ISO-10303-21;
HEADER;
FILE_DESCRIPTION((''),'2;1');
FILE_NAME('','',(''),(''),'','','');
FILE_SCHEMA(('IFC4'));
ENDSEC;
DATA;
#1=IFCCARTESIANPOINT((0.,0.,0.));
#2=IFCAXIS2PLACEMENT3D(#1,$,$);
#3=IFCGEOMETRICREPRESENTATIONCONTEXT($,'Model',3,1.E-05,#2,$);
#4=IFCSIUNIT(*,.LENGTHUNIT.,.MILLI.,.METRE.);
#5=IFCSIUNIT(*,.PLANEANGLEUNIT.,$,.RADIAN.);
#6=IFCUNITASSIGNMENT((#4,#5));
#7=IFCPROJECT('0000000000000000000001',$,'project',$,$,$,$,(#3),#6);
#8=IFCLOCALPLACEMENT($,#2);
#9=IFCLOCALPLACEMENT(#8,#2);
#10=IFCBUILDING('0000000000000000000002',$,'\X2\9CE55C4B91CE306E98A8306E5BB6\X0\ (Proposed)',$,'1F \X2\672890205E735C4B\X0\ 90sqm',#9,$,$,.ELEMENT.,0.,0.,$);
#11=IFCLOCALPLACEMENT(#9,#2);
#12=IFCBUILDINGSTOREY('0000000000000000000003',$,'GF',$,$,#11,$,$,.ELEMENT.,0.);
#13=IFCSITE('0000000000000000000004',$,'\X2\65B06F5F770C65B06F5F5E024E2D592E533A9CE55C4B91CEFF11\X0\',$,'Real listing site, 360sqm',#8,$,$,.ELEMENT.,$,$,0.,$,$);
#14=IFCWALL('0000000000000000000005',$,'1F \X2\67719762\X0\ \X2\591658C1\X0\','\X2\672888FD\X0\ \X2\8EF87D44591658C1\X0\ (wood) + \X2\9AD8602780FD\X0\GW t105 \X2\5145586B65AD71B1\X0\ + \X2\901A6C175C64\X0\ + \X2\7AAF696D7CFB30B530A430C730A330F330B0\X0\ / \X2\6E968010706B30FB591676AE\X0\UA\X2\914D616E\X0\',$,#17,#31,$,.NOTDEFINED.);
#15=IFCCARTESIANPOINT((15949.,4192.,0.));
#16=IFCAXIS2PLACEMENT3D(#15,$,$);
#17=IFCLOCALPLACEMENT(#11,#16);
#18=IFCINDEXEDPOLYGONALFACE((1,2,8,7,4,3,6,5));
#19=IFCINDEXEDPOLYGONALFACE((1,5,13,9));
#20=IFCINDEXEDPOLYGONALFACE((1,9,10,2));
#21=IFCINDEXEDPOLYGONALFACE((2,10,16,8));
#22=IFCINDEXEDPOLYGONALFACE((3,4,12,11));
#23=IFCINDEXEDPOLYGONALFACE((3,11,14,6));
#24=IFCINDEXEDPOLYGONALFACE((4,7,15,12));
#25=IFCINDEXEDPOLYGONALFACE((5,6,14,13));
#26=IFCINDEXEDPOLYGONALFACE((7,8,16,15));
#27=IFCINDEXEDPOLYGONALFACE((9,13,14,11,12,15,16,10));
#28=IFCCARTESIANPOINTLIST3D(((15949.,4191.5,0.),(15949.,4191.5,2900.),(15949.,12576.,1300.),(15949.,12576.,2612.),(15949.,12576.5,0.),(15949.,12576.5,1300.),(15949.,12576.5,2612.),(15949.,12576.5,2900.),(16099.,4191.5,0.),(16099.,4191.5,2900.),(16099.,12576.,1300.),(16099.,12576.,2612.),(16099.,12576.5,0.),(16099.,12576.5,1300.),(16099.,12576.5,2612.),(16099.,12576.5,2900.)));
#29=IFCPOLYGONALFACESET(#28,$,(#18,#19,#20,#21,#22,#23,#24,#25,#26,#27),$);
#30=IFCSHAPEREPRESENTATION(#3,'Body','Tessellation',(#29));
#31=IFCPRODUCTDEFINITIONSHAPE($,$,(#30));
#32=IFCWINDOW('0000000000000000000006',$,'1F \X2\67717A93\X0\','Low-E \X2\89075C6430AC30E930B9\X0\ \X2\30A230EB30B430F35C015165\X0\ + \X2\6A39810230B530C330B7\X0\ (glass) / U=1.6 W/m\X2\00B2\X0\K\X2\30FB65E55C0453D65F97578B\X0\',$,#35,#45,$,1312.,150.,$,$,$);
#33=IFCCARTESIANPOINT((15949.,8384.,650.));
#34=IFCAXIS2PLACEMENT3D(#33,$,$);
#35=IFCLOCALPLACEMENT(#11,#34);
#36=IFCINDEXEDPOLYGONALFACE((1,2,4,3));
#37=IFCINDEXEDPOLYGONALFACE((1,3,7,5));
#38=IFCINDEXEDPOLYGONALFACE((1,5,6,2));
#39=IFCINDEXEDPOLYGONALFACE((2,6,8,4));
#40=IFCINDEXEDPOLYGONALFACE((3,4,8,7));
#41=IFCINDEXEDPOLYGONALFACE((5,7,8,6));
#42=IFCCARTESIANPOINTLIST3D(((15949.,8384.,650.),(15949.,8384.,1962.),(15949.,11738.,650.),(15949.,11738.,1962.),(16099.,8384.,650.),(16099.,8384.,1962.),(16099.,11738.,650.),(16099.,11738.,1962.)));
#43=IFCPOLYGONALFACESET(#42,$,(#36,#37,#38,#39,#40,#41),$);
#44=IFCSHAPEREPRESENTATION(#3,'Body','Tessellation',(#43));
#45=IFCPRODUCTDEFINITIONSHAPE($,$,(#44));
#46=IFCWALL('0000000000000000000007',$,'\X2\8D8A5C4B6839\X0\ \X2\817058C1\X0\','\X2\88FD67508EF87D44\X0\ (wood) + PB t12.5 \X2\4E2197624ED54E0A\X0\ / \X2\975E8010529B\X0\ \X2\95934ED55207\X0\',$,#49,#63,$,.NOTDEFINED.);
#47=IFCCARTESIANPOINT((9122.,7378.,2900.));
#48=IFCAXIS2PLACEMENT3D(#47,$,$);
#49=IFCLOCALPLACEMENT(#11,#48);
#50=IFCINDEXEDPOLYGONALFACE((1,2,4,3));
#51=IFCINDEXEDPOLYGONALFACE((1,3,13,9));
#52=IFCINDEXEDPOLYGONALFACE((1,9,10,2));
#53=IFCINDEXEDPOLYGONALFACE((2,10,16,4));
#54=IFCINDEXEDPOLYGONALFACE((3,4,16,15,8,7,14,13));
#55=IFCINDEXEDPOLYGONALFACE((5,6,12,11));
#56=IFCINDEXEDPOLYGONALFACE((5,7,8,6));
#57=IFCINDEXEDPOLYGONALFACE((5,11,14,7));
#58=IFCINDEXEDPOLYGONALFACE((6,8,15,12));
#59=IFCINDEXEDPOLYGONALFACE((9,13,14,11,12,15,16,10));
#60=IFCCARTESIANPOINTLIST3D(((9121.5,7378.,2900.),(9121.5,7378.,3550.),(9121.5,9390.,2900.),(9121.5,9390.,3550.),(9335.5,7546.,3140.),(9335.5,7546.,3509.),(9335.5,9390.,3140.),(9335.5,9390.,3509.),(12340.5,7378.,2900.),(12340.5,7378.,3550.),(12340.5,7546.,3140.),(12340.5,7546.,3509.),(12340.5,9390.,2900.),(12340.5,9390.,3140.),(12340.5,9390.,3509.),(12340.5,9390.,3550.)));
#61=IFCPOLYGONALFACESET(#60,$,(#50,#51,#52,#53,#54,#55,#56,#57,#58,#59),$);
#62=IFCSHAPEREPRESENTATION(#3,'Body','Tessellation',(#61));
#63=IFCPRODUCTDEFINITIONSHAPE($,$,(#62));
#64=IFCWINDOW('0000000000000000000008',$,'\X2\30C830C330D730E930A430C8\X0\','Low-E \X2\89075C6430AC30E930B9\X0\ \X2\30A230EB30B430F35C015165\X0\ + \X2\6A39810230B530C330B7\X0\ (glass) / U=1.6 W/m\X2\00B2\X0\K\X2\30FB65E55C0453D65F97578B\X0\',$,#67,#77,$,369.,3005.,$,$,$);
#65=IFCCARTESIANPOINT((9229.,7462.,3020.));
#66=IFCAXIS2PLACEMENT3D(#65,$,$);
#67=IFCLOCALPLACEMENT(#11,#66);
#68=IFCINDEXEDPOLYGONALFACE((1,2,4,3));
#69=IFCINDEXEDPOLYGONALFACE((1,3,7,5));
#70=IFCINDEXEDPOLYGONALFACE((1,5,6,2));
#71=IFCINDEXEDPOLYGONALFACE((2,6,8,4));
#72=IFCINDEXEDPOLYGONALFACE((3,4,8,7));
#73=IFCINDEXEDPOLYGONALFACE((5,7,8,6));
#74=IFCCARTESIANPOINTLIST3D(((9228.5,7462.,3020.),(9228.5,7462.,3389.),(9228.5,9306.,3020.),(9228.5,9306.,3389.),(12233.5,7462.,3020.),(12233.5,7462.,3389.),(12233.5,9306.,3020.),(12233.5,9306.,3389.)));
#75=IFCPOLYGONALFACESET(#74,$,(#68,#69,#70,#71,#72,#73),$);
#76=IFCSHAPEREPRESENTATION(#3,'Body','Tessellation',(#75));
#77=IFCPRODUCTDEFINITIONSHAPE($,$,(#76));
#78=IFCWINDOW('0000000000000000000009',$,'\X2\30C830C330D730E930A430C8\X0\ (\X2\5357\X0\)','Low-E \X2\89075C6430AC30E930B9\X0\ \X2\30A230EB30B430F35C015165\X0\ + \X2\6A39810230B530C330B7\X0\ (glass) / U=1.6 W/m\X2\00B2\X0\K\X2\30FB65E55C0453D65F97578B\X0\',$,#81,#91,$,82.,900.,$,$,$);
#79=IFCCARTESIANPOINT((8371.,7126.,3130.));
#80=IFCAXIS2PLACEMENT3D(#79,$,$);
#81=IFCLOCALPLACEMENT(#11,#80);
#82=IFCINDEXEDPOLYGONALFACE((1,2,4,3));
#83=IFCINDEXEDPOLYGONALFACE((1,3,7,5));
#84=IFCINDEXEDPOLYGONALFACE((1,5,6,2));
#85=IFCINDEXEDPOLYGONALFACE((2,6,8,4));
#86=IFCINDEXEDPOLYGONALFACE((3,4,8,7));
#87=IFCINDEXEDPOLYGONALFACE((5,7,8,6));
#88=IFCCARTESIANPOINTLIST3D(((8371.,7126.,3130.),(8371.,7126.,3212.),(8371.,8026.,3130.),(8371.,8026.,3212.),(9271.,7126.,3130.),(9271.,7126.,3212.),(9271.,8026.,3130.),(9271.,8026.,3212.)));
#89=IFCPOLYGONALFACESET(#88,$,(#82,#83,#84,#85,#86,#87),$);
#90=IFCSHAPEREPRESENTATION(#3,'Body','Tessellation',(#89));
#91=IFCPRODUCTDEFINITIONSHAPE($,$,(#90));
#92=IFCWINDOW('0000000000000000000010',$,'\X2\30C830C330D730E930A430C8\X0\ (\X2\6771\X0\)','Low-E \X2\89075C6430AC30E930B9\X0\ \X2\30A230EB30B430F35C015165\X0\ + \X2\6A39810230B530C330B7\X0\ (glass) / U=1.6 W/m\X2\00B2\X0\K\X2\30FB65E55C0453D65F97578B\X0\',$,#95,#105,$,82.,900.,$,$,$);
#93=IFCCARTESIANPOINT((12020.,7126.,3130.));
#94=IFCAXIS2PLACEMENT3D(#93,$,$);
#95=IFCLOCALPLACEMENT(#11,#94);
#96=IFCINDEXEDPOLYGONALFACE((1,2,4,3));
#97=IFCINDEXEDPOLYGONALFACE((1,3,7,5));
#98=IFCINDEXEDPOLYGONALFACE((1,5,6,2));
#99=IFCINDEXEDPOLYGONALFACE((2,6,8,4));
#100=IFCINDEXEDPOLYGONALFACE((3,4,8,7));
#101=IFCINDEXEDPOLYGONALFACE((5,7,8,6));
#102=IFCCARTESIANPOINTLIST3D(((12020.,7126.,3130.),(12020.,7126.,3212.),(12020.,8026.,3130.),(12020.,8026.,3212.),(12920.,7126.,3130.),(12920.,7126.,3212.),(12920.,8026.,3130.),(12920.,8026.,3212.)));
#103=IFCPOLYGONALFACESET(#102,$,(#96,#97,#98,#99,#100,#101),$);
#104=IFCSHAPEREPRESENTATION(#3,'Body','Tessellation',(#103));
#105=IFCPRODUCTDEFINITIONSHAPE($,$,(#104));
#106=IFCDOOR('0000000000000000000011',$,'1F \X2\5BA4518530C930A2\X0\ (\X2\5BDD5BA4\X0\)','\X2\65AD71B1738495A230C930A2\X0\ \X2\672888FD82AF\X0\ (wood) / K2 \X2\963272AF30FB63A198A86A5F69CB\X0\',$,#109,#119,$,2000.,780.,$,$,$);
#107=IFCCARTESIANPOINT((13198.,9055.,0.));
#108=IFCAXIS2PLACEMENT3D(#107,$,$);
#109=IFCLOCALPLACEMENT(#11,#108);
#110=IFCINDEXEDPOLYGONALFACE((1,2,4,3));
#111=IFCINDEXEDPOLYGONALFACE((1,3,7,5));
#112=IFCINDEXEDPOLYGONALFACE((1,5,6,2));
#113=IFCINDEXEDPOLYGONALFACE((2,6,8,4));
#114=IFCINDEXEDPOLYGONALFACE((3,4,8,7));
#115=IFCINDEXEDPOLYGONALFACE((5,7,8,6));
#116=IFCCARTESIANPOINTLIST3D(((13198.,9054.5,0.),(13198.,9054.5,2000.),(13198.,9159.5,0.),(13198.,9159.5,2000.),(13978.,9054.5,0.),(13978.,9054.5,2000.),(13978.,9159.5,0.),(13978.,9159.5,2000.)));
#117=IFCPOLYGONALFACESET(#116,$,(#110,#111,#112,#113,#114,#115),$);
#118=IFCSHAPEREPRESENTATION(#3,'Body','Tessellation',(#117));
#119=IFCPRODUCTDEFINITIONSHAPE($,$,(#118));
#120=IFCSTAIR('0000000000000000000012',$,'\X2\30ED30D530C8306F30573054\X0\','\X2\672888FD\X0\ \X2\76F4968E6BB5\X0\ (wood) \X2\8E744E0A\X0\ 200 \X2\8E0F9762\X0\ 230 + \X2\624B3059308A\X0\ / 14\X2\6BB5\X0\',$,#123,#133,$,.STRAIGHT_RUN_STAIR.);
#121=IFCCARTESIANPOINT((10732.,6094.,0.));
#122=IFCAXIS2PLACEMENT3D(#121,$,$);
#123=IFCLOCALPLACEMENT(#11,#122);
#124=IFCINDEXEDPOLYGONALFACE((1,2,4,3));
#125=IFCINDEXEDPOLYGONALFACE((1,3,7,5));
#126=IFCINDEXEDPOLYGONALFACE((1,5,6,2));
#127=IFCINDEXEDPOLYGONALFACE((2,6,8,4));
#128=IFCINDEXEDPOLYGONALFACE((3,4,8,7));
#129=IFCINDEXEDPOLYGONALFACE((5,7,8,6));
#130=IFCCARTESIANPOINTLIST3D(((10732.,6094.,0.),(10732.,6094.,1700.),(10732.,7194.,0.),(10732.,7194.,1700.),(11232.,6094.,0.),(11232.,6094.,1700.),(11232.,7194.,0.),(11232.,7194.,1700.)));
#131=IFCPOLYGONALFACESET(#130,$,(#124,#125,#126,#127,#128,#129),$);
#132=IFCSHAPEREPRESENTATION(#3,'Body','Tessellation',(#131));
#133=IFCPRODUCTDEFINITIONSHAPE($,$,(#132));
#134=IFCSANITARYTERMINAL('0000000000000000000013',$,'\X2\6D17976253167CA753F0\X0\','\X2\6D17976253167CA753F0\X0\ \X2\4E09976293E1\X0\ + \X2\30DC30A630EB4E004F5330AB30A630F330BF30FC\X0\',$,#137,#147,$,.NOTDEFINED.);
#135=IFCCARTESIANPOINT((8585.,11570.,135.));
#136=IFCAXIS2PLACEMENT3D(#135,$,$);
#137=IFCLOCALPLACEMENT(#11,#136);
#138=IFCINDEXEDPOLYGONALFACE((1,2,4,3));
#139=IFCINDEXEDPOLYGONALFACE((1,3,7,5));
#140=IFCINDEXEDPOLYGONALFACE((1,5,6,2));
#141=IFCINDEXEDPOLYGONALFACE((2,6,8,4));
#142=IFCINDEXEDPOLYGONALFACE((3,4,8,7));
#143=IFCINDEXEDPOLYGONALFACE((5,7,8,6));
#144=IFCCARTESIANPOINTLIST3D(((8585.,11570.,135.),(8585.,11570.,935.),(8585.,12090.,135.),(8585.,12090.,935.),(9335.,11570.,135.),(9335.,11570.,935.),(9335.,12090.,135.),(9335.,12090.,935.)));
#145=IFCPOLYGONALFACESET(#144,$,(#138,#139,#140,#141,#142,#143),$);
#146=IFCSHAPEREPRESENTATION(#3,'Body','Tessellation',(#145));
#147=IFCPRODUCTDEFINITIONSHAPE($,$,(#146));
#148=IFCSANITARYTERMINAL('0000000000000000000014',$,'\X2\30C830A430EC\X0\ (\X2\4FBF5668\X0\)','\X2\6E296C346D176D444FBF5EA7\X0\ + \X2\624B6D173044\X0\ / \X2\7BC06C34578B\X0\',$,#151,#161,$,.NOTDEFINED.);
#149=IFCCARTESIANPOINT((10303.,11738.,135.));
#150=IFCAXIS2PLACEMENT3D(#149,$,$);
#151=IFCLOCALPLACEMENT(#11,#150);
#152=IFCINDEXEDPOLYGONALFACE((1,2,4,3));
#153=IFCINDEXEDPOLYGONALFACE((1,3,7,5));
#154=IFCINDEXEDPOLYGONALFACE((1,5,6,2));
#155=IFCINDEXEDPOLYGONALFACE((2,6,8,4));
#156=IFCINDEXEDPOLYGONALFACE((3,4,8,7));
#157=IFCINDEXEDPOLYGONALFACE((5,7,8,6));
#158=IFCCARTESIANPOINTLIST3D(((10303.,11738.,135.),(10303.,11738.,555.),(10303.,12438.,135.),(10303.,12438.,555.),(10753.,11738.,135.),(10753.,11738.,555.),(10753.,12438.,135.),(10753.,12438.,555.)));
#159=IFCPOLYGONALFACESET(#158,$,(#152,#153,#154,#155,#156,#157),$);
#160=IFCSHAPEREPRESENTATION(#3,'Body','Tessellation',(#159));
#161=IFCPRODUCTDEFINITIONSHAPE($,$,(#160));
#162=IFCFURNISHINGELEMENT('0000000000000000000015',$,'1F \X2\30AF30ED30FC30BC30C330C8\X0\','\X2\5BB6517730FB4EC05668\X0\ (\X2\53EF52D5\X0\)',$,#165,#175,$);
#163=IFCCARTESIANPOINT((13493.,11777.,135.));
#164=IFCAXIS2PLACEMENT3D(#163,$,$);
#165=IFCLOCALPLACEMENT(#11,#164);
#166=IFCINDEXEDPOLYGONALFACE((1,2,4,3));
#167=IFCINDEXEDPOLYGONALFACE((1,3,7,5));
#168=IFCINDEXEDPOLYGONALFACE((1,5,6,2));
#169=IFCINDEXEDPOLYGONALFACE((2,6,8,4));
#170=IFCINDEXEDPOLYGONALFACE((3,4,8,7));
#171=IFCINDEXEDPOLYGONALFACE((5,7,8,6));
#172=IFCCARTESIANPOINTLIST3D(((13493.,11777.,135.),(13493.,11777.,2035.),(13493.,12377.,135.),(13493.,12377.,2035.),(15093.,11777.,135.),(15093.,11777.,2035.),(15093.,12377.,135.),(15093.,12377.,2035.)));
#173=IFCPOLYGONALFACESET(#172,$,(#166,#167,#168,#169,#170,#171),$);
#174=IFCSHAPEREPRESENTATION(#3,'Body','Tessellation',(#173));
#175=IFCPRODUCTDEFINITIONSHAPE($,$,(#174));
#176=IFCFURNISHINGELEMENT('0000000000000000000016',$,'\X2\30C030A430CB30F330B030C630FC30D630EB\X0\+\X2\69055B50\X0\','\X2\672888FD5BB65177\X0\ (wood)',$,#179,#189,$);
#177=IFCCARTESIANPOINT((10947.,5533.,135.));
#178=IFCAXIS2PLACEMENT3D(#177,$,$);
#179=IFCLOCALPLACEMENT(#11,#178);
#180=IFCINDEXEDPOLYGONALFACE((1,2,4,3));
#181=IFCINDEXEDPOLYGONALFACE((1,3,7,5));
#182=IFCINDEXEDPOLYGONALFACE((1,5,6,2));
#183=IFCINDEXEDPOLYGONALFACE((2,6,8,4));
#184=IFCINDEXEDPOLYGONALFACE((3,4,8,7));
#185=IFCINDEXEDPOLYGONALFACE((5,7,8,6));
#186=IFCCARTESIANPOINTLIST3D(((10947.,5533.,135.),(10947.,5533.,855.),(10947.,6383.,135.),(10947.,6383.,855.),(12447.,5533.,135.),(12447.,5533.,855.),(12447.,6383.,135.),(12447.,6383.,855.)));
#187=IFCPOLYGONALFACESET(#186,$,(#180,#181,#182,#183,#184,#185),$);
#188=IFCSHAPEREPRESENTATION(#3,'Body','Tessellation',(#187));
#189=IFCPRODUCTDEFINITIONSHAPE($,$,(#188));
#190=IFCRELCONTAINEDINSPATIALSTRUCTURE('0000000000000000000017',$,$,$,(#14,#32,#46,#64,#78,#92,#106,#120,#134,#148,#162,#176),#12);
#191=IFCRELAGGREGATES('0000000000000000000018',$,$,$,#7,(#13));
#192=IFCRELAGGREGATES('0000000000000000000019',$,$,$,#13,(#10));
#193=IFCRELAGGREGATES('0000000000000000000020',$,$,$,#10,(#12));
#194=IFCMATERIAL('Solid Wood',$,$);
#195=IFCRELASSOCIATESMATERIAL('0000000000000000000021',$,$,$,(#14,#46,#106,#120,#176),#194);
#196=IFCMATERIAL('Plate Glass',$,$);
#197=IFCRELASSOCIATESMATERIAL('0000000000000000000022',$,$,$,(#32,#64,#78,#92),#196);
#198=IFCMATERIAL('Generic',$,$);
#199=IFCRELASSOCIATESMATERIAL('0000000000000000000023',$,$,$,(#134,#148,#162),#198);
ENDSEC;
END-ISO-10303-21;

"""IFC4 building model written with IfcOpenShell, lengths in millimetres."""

from ifc_helpers import new_model, si_unit, frame, frame_2d, origin, place, context, project, spatial, rectangle, extrude, material, element, fill, save


model = new_model("IFC4")

# Units and contexts
model_context = context("Model", 3, precision=1e-05, world=origin())
ifc_project = project(units=[si_unit("LENGTHUNIT", "METRE", prefix="MILLI"), si_unit("PLANEANGLEUNIT", "RADIAN")], contexts=[model_context])

# Site, building, storey
site_placement = place(None, origin())
site = spatial("IfcSite", under=ifc_project, at=site_placement, Name="新潟県新潟市中央区鳥屋野１", ObjectType="Real listing site, 360sqm", CompositionType="ELEMENT", RefElevation=0.0)
building_placement = place(site_placement, origin())
building = spatial("IfcBuilding", under=site, at=building_placement, Name="鳥屋野の風の家 (Proposed)", ObjectType="1F 木造平屋 90sqm", CompositionType="ELEMENT", ElevationOfRefHeight=0.0, ElevationOfTerrain=0.0)
storey_placement = place(building_placement, origin())
storey = spatial("IfcBuildingStorey", under=building, at=storey_placement, Name="GF", CompositionType="ELEMENT", Elevation=0.0)

# Wall, opening, window
ifc_material_1 = material(Name="Solid Wood")
wall_1_placement = place(storey_placement, frame((15949.0, 4192.0, 0.0)))
wall_1 = element("IfcWall", 1, at=wall_1_placement, inside=storey, material=ifc_material_1, Name="1F 東面 外壁", Description="木製 軸組外壁 (wood) + 高性能GW t105 充填断熱 + 通気層 + 窯業系サイディング / 準耐火・外皮UA配慮", PredefinedType="NOTDEFINED", context=model_context, shape_type="SweptSolid", body=[
    extrude(rectangle(XDim=150.0, YDim=8385.0, at=frame_2d((75.0, 4192.0))), frame((15949.0, 4192.0, 0.0)), (0.0, 0.0, 1.0), 2900.0),
])
opening_1_placement = place(storey_placement, frame((15949.0, 8384.0, 650.0)))
opening_1 = element("IfcOpeningElement", 2, at=opening_1_placement, cuts=wall_1, PredefinedType="NOTDEFINED", context=model_context, shape_type="SweptSolid", body=[
    extrude(rectangle(XDim=150.0, YDim=3354.0, at=frame_2d((75.0, 1677.0))), frame((15949.0, 8384.0, 650.0)), (0.0, 0.0, 1.0), 1312.0),
])
ifc_material_2 = material(Name="Plate Glass")
window_1_placement = place(storey_placement, frame((15949.0, 8384.0, 650.0)))
window_1 = element("IfcWindow", 3, at=window_1_placement, inside=storey, material=ifc_material_2, Name="1F 東窓", Description="Low-E 複層ガラス アルゴン封入 + 樹脂サッシ (glass) / U=1.6 W/m²K・日射取得型", OverallHeight=1312.0, OverallWidth=150.0, context=model_context, shape_type="SweptSolid", body=[
    extrude(rectangle(XDim=150.0, YDim=3354.0, at=frame_2d((75.0, 1677.0))), frame((15949.0, 8384.0, 650.0)), (0.0, 0.0, 1.0), 1312.0),
])
fill(opening_1, window_1)

# Wall, openings, windows
wall_2_placement = place(storey_placement, frame((9122.0, 7378.0, 2900.0)))
wall_2 = element("IfcWall", 4, at=wall_2_placement, inside=storey, material=ifc_material_1, Name="越屋根 腰壁", Description="製材軸組 (wood) + PB t12.5 両面仕上 / 非耐力 間仕切", PredefinedType="NOTDEFINED", context=model_context, shape_type="SweptSolid", body=[
    extrude(rectangle(XDim=3219.0, YDim=2012.0, at=frame_2d((1609.0, 1006.0))), frame((9122.0, 7378.0, 2900.0)), (0.0, 0.0, 1.0), 650.0),
])
opening_2_placement = place(storey_placement, frame((9229.0, 7462.0, 3020.0)))
opening_2 = element("IfcOpeningElement", 5, at=opening_2_placement, cuts=wall_2, PredefinedType="NOTDEFINED", context=model_context, shape_type="SweptSolid", body=[
    extrude(rectangle(XDim=3005.0, YDim=1844.0, at=frame_2d((1502.0, 922.0))), frame((9229.0, 7462.0, 3020.0)), (0.0, 0.0, 1.0), 369.0),
])
opening_3_placement = place(storey_placement, frame((8371.0, 7126.0, 3130.0)))
opening_3 = element("IfcOpeningElement", 6, at=opening_3_placement, cuts=wall_2, PredefinedType="NOTDEFINED", context=model_context, shape_type="SweptSolid", body=[
    extrude(rectangle(XDim=900.0, YDim=900.0, at=frame_2d((450.0, 450.0))), frame((8371.0, 7126.0, 3130.0)), (0.0, 0.0, 1.0), 82.0),
])
opening_4_placement = place(storey_placement, frame((12020.0, 7126.0, 3130.0)))
opening_4 = element("IfcOpeningElement", 7, at=opening_4_placement, cuts=wall_2, PredefinedType="NOTDEFINED", context=model_context, shape_type="SweptSolid", body=[
    extrude(rectangle(XDim=900.0, YDim=900.0, at=frame_2d((450.0, 450.0))), frame((12020.0, 7126.0, 3130.0)), (0.0, 0.0, 1.0), 82.0),
])
window_2_placement = place(storey_placement, frame((9229.0, 7462.0, 3020.0)))
window_2 = element("IfcWindow", 8, at=window_2_placement, inside=storey, material=ifc_material_2, Name="トップライト", Description="Low-E 複層ガラス アルゴン封入 + 樹脂サッシ (glass) / U=1.6 W/m²K・日射取得型", OverallHeight=369.0, OverallWidth=3005.0, context=model_context, shape_type="SweptSolid", body=[
    extrude(rectangle(XDim=3005.0, YDim=1844.0, at=frame_2d((1502.0, 922.0))), frame((9229.0, 7462.0, 3020.0)), (0.0, 0.0, 1.0), 369.0),
])
fill(opening_2, window_2)
window_3_placement = place(storey_placement, frame((8371.0, 7126.0, 3130.0)))
window_3 = element("IfcWindow", 9, at=window_3_placement, inside=storey, material=ifc_material_2, Name="トップライト (南)", Description="Low-E 複層ガラス アルゴン封入 + 樹脂サッシ (glass) / U=1.6 W/m²K・日射取得型", OverallHeight=82.0, OverallWidth=900.0, context=model_context, shape_type="SweptSolid", body=[
    extrude(rectangle(XDim=900.0, YDim=900.0, at=frame_2d((450.0, 450.0))), frame((8371.0, 7126.0, 3130.0)), (0.0, 0.0, 1.0), 82.0),
])
fill(opening_3, window_3)
window_4_placement = place(storey_placement, frame((12020.0, 7126.0, 3130.0)))
window_4 = element("IfcWindow", 10, at=window_4_placement, inside=storey, material=ifc_material_2, Name="トップライト (東)", Description="Low-E 複層ガラス アルゴン封入 + 樹脂サッシ (glass) / U=1.6 W/m²K・日射取得型", OverallHeight=82.0, OverallWidth=900.0, context=model_context, shape_type="SweptSolid", body=[
    extrude(rectangle(XDim=900.0, YDim=900.0, at=frame_2d((450.0, 450.0))), frame((12020.0, 7126.0, 3130.0)), (0.0, 0.0, 1.0), 82.0),
])
fill(opening_4, window_4)

# Door
door_placement = place(storey_placement, frame((13198.0, 9055.0, 0.0)))
element("IfcDoor", 11, at=door_placement, inside=storey, material=ifc_material_1, Name="1F 室内ドア (寝室)", Description="断熱玄関ドア 木製芯 (wood) / K2 防犯・採風機構", OverallHeight=2000.0, OverallWidth=780.0, context=model_context, shape_type="SweptSolid", body=[
    extrude(rectangle(XDim=780.0, YDim=105.0, at=frame_2d((390.0, 52.0))), frame((13198.0, 9055.0, 0.0)), (0.0, 0.0, 1.0), 2000.0),
])

# Stair
stair_placement = place(storey_placement, frame((10732.0, 6094.0, 0.0)))
element("IfcStair", 12, at=stair_placement, inside=storey, material=ifc_material_1, Name="ロフトはしご", Description="木製 直階段 (wood) 蹴上 200 踏面 230 + 手すり / 14段", PredefinedType="STRAIGHT_RUN_STAIR", context=model_context, shape_type="SweptSolid", body=[
    extrude(rectangle(XDim=500.0, YDim=1100.0, at=frame_2d((250.0, 550.0))), frame((10732.0, 6094.0, 0.0)), (0.0, 0.0, 1.0), 1700.0),
])

# Sanitary terminals
ifc_material_3 = material(Name="Generic")
sanitary_terminal_1_placement = place(storey_placement, frame((8585.0, 11570.0, 135.0)))
element("IfcSanitaryTerminal", 13, at=sanitary_terminal_1_placement, inside=storey, material=ifc_material_3, Name="洗面化粧台", Description="洗面化粧台 三面鏡 + ボウル一体カウンター", PredefinedType="NOTDEFINED", context=model_context, shape_type="SweptSolid", body=[
    extrude(rectangle(XDim=750.0, YDim=520.0, at=frame_2d((375.0, 260.0))), frame((8585.0, 11570.0, 135.0)), (0.0, 0.0, 1.0), 800.0),
])
sanitary_terminal_2_placement = place(storey_placement, frame((10303.0, 11738.0, 135.0)))
element("IfcSanitaryTerminal", 14, at=sanitary_terminal_2_placement, inside=storey, material=ifc_material_3, Name="トイレ (便器)", Description="温水洗浄便座 + 手洗い / 節水型", PredefinedType="NOTDEFINED", context=model_context, shape_type="SweptSolid", body=[
    extrude(rectangle(XDim=450.0, YDim=700.0, at=frame_2d((225.0, 350.0))), frame((10303.0, 11738.0, 135.0)), (0.0, 0.0, 1.0), 420.0),
])

# Furnishing elements
furnishing_1_placement = place(storey_placement, frame((13493.0, 11777.0, 135.0)))
element("IfcFurnishingElement", 15, at=furnishing_1_placement, inside=storey, material=ifc_material_3, Name="1F クローゼット", Description="家具・什器 (可動)", context=model_context, shape_type="SweptSolid", body=[
    extrude(rectangle(XDim=1600.0, YDim=600.0, at=frame_2d((800.0, 300.0))), frame((13493.0, 11777.0, 135.0)), (0.0, 0.0, 1.0), 1900.0),
])
furnishing_2_placement = place(storey_placement, frame((10947.0, 5533.0, 135.0)))
element("IfcFurnishingElement", 16, at=furnishing_2_placement, inside=storey, material=ifc_material_1, Name="ダイニングテーブル+椅子", Description="木製家具 (wood)", context=model_context, shape_type="SweptSolid", body=[
    extrude(rectangle(XDim=1500.0, YDim=850.0, at=frame_2d((750.0, 425.0))), frame((10947.0, 5533.0, 135.0)), (0.0, 0.0, 1.0), 720.0),
])

save(model, "model.ifc")
